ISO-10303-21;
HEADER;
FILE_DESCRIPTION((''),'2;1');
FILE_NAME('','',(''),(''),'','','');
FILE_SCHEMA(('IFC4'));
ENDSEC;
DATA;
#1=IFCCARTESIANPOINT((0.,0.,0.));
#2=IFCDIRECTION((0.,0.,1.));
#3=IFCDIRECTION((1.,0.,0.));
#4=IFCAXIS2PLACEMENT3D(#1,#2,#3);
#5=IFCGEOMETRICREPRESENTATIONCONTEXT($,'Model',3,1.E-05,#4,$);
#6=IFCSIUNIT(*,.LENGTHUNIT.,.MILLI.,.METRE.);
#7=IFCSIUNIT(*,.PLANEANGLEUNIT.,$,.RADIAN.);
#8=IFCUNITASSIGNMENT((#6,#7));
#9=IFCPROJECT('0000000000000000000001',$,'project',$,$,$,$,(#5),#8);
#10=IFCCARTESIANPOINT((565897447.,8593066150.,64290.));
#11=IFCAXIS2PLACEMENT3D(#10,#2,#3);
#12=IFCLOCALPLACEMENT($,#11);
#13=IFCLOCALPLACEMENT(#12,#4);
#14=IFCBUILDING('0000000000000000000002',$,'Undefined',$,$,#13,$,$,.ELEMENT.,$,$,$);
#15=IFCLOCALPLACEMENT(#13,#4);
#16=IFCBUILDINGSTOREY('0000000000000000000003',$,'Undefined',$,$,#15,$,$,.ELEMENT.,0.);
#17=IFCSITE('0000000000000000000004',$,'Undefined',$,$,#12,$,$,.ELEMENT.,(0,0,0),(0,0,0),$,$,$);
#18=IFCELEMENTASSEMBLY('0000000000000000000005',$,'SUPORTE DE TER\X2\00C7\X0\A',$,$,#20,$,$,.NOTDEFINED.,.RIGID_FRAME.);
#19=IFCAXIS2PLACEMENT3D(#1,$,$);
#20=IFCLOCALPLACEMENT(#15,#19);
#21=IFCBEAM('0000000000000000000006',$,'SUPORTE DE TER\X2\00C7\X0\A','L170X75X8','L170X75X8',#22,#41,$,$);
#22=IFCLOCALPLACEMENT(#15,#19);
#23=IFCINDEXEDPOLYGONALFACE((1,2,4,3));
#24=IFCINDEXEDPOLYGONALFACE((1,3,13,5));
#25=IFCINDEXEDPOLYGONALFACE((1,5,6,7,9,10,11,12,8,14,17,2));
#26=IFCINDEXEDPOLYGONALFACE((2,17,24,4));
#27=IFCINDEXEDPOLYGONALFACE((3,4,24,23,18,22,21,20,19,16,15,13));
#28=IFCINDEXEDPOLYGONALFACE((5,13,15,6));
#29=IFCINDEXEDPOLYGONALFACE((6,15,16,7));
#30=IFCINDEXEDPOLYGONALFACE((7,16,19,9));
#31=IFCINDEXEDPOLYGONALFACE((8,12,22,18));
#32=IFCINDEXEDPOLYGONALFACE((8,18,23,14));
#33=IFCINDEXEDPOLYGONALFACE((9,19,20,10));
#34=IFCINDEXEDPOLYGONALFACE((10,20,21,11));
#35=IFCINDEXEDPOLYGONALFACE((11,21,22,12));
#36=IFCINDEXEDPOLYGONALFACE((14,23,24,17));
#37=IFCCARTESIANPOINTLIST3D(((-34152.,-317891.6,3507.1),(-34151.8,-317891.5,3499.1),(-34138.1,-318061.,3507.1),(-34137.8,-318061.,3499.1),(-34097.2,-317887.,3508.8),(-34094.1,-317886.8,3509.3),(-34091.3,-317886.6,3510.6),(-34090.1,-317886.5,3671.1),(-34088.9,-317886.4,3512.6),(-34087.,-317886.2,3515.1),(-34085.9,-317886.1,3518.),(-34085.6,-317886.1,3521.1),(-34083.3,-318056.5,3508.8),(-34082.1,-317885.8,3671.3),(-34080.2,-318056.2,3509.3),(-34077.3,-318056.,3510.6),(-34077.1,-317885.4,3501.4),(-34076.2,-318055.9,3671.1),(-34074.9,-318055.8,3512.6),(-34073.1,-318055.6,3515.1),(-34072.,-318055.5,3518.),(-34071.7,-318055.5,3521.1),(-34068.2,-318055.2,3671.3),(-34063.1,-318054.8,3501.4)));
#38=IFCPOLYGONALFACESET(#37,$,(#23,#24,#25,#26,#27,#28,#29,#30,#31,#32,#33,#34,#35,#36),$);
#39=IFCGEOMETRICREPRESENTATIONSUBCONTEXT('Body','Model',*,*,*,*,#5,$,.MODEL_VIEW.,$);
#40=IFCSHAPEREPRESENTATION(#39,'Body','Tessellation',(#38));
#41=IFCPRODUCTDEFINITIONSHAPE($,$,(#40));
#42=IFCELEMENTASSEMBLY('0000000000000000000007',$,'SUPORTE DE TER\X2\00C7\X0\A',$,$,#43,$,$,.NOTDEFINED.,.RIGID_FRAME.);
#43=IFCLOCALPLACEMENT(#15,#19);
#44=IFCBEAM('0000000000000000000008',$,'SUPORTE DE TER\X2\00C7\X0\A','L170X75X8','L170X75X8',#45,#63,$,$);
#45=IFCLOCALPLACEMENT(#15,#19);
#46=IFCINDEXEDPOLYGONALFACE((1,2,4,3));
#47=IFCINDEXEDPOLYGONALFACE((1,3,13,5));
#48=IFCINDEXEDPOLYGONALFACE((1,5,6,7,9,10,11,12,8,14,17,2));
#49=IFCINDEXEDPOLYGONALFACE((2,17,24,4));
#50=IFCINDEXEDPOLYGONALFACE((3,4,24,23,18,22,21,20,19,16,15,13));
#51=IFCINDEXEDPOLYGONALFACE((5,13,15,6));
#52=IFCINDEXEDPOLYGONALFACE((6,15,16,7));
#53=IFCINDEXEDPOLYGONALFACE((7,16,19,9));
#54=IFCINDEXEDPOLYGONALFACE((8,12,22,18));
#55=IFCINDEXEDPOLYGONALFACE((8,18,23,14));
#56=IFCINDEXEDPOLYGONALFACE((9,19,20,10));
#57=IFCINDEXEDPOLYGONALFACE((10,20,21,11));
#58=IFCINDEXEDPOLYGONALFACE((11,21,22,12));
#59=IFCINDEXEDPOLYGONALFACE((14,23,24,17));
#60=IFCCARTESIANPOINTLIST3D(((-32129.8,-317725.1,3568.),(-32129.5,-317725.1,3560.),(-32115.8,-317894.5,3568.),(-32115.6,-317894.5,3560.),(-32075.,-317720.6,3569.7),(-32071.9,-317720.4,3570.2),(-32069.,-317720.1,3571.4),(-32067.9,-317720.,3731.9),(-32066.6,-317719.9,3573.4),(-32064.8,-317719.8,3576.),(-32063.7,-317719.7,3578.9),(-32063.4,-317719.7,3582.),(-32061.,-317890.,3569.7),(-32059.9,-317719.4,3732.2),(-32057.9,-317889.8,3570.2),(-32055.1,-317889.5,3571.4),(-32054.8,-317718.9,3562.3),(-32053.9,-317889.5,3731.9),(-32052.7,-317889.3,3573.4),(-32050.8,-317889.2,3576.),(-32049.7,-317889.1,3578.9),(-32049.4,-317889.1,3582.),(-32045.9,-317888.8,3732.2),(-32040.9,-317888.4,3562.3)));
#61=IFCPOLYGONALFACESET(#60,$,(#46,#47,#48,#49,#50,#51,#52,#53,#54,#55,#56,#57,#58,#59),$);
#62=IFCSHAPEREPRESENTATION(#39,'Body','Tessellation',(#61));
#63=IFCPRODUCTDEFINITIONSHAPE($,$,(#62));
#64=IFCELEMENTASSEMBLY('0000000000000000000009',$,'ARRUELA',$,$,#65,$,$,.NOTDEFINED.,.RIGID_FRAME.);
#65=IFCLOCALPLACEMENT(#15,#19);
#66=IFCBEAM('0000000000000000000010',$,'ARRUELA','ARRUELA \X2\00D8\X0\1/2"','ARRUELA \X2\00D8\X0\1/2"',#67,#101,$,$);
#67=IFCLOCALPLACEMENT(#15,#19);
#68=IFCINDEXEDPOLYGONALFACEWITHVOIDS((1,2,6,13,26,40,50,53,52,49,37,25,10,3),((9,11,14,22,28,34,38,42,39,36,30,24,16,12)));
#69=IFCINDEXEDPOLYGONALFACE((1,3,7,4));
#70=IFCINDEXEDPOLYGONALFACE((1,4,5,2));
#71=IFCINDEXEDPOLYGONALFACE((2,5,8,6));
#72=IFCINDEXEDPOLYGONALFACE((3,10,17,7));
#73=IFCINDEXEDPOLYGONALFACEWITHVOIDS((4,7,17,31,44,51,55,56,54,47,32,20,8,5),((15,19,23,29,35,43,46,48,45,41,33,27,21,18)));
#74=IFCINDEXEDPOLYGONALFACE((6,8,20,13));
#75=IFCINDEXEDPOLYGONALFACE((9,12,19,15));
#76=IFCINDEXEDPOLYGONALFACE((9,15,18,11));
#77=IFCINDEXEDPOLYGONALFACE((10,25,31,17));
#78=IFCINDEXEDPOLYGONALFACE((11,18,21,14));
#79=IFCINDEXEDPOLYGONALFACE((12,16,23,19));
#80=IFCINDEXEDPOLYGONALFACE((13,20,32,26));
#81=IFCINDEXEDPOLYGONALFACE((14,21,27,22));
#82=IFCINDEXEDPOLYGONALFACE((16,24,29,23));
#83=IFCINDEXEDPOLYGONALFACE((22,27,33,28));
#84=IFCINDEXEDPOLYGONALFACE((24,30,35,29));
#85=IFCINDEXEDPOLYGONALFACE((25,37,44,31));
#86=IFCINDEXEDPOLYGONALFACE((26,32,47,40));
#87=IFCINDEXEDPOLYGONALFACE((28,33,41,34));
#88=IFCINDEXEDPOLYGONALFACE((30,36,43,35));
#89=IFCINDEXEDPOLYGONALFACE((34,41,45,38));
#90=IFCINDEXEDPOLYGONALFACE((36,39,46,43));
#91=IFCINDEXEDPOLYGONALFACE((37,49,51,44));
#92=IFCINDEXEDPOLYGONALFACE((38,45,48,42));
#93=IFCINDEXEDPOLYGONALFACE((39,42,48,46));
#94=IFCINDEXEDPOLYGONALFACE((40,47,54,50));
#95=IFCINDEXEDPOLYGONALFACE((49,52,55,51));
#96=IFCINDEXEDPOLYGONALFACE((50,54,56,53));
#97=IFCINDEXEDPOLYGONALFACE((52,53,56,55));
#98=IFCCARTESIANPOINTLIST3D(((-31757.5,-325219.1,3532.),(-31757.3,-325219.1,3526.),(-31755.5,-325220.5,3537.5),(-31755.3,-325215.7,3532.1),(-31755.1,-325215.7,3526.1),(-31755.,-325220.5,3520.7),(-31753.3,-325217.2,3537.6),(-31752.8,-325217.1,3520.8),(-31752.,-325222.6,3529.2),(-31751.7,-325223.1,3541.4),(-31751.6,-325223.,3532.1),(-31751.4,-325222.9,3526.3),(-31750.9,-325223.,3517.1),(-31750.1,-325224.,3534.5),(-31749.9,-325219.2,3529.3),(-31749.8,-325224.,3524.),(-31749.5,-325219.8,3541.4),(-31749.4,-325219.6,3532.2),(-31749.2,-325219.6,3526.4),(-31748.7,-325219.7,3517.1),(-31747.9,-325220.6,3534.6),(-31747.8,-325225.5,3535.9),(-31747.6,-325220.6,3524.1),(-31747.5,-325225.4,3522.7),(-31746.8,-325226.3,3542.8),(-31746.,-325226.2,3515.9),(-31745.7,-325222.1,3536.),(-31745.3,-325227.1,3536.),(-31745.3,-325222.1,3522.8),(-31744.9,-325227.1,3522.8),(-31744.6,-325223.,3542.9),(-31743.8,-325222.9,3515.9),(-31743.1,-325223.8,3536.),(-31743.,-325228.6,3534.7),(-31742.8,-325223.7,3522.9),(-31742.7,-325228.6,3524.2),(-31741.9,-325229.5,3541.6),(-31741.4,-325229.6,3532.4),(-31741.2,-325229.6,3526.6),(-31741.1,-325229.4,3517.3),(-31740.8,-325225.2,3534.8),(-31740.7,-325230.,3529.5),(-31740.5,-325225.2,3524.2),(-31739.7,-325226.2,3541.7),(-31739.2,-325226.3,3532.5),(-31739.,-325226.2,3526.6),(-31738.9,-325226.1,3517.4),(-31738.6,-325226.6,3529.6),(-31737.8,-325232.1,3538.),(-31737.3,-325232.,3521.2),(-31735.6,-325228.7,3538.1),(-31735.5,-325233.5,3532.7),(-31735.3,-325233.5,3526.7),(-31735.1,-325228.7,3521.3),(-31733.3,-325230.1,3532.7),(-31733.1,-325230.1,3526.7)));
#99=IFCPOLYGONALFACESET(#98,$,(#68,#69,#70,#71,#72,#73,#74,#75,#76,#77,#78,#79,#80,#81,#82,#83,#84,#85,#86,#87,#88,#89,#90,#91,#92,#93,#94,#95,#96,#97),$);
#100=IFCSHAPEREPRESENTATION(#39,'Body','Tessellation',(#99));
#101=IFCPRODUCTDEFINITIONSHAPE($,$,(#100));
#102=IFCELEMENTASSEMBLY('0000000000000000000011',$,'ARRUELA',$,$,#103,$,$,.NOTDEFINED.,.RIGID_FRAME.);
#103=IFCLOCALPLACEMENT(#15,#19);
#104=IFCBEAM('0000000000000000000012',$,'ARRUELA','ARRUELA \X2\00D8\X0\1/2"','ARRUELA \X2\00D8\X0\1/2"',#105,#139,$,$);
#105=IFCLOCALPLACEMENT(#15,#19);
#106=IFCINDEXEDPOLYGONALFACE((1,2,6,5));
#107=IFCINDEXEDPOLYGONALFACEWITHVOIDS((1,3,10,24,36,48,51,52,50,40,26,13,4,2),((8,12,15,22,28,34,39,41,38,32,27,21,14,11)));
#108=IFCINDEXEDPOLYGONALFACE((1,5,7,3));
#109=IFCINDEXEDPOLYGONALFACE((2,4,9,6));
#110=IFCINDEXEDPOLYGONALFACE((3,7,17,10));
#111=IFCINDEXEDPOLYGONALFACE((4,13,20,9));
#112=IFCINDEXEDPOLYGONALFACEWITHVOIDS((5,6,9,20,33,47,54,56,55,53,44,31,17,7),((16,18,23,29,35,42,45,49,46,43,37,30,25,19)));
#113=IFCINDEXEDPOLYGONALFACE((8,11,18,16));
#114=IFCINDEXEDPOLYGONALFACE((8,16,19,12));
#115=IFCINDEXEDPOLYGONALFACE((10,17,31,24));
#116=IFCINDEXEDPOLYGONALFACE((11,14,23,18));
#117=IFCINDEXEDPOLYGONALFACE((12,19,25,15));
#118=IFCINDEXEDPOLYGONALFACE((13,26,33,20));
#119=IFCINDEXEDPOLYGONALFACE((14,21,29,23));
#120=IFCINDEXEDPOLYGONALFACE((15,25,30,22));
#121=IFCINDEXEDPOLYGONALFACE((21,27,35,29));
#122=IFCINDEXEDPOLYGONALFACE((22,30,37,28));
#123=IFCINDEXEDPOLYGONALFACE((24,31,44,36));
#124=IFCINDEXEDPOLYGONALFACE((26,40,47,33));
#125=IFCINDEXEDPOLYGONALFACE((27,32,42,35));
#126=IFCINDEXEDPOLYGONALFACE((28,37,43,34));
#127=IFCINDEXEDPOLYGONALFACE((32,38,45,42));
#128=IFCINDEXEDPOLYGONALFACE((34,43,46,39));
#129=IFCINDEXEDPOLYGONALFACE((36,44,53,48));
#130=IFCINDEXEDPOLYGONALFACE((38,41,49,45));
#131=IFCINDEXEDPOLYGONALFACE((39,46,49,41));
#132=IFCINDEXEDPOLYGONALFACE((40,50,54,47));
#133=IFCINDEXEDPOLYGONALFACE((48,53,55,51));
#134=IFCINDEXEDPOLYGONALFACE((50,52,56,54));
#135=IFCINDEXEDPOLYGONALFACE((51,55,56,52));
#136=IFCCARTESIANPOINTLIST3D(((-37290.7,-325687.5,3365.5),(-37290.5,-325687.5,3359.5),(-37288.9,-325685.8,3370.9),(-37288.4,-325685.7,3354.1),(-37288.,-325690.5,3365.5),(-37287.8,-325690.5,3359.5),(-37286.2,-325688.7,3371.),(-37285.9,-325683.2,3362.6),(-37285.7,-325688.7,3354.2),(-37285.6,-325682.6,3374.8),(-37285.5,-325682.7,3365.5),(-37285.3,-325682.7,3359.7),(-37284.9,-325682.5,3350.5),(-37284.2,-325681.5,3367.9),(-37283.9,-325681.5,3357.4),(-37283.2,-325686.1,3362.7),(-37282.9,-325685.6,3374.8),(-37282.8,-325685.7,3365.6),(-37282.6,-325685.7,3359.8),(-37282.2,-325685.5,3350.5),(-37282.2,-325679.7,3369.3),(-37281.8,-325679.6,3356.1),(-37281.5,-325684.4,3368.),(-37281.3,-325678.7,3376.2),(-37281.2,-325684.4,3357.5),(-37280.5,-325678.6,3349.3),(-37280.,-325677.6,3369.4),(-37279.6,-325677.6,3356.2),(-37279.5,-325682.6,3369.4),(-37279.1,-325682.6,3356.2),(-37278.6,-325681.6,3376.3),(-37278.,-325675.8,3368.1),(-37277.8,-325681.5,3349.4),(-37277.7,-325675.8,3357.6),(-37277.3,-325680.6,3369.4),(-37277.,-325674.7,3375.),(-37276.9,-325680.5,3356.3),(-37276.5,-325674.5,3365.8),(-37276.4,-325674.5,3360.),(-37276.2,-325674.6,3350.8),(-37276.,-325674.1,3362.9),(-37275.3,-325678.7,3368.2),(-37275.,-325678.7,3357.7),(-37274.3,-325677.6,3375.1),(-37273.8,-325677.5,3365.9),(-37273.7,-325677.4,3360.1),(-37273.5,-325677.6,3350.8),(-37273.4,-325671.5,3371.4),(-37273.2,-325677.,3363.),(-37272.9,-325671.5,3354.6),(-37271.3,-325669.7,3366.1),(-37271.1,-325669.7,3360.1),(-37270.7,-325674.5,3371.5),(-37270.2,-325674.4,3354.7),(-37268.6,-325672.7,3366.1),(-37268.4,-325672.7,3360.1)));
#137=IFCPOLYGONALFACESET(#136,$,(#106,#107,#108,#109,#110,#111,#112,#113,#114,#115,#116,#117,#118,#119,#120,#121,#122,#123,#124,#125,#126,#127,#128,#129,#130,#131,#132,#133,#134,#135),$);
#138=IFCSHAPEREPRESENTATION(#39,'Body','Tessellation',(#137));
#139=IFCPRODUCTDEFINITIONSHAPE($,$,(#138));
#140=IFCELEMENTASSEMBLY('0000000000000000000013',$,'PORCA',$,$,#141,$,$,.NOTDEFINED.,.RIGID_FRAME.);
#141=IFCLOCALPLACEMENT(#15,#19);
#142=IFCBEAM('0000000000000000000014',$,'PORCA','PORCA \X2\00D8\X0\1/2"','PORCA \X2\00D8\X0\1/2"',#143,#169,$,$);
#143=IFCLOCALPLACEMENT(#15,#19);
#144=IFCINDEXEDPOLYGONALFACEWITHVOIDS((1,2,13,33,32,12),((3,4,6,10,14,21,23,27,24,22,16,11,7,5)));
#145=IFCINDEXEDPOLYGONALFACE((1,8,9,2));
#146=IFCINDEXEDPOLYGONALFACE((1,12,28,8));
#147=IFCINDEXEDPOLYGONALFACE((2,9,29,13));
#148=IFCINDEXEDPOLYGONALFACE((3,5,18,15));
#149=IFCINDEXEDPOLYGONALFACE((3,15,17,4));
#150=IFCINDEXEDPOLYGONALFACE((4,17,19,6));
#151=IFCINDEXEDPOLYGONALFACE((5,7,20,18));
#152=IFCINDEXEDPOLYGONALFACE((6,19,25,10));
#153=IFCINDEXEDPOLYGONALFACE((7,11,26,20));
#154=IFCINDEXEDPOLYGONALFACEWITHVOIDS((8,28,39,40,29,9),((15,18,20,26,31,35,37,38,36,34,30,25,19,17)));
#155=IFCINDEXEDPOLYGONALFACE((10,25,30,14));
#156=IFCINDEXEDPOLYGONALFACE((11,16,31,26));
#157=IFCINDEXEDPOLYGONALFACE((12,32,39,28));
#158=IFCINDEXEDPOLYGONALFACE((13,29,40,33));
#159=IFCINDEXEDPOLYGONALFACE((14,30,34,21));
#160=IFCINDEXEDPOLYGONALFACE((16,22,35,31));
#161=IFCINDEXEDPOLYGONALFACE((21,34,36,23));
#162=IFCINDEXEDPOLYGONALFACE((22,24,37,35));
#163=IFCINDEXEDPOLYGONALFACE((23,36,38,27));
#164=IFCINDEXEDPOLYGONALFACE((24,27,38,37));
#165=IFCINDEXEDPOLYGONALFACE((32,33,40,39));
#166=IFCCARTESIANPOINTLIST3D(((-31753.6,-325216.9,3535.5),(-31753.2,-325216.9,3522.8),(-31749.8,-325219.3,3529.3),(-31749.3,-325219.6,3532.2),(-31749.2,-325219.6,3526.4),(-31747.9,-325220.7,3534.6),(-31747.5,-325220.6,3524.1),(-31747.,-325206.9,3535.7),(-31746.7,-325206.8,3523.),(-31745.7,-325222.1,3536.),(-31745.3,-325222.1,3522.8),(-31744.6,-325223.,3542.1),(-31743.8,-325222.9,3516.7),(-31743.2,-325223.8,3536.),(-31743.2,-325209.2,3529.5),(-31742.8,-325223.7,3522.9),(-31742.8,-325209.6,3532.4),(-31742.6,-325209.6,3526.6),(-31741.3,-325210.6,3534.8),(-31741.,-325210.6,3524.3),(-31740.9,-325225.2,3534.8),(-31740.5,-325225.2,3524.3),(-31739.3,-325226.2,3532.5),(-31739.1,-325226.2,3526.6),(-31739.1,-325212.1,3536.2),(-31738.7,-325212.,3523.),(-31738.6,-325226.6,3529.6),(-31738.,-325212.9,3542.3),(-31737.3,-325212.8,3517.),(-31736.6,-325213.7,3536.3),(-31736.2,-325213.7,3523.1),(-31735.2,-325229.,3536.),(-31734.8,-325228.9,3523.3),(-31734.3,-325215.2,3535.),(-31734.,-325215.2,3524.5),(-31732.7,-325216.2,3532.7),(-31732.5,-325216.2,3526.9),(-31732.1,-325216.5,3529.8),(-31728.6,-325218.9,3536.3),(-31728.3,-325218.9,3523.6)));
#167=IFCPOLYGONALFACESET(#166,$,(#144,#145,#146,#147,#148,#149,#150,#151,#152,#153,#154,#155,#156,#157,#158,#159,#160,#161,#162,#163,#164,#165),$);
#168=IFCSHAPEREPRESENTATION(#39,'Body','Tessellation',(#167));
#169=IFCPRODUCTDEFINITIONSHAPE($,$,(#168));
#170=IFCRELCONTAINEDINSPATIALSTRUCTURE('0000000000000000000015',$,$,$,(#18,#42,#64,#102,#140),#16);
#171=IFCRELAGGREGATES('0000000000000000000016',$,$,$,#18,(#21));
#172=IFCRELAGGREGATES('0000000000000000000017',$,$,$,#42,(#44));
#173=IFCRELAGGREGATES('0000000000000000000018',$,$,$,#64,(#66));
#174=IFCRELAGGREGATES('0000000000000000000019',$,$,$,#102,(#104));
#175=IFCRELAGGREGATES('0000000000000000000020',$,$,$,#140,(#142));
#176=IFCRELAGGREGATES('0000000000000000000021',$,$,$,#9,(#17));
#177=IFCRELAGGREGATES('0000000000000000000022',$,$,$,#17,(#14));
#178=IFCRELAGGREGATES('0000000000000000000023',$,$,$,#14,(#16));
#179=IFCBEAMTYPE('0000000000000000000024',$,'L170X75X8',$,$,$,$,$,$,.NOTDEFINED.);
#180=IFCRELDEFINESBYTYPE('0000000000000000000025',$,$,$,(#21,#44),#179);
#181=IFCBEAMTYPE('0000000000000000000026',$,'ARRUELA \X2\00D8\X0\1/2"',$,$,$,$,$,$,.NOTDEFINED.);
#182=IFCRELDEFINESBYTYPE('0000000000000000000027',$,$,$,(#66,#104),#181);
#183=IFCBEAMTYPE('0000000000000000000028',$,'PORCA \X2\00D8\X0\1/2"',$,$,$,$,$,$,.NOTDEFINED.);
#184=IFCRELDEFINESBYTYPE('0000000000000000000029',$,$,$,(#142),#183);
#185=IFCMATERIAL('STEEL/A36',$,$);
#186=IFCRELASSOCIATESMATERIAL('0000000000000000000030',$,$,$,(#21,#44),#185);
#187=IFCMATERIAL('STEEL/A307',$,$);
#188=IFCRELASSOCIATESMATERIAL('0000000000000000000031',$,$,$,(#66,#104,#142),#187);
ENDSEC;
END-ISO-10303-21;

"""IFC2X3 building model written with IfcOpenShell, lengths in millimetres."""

from ifc_helpers import new_model, si_unit, frame, origin_with_axes, origin_2d_with_axis, place, context, subcontext, project, spatial, polyline, l_section, outline, extrude, material, type_object, element, aggregate, save


model = new_model("IFC2X3")

# Units and contexts
model_context = context("Model", 3, precision=1e-05, world=origin_with_axes())
body_context = subcontext(model_context, "Body", "Model", "MODEL_VIEW")
ifc_project = project(units=[si_unit("LENGTHUNIT", "METRE", prefix="MILLI"), si_unit("PLANEANGLEUNIT", "RADIAN")], contexts=[model_context])

# Site, building, storey
site_placement = place(None, frame((565897447.0, 8593066150.0, 64290.0), z_axis=(0.0, 0.0, 1.0), x_axis=(1.0, 0.0, 0.0)))
site = spatial("IfcSite", under=ifc_project, at=site_placement, Name="Undefined", CompositionType="ELEMENT", RefLatitude=(0, 0, 0), RefLongitude=(0, 0, 0))
building_placement = place(site_placement, origin_with_axes())
building = spatial("IfcBuilding", under=site, at=building_placement, Name="Undefined", CompositionType="ELEMENT")
storey_placement = place(building_placement, origin_with_axes())
storey = spatial("IfcBuildingStorey", under=building, at=storey_placement, Name="Undefined", CompositionType="ELEMENT", Elevation=0.0)

# Element assemblies, beams
ifc_material_1 = material(Name="STEEL/A36")
beam_type_1 = type_object("IfcBeamType", Name="L170X75X8", PredefinedType="NOTDEFINED")
assembly_1_placement = place(storey_placement, origin_with_axes())
assembly_1 = element("IfcElementAssembly", 1, at=assembly_1_placement, inside=storey, Name="SUPORTE DE TERÇA", AssemblyPlace="NOTDEFINED", PredefinedType="RIGID_FRAME")
beam_1_placement = place(assembly_1_placement, frame((-34117.0, -317888.7, 3585.2), z_axis=(-0.029885, -0.00246, 0.99955), x_axis=(0.082025, -0.99663, 0.0)))
beam_1 = element("IfcBeam", 2, at=beam_1_placement, type_object=beam_type_1, material=ifc_material_1, Name="SUPORTE DE TERÇA", Description="L170X75X8", ObjectType="L170X75X8", context=body_context, shape_type="SweptSolid", body=[
    extrude(l_section(Depth=170.0, Width=75.0, Thickness=8.0, FilletRadius=12.0, at=origin_2d_with_axis()), frame((170.0, 0.0, 0.0), z_axis=(-1.0, 0.0, 0.0), x_axis=(0.0, -1.0, 0.0)), (0.0, 0.0, 1.0), 170.0),
])
aggregate(assembly_1, [beam_1])
assembly_2_placement = place(storey_placement, origin_with_axes())
assembly_2 = element("IfcElementAssembly", 3, at=assembly_2_placement, inside=storey, Name="SUPORTE DE TERÇA", AssemblyPlace="NOTDEFINED", PredefinedType="RIGID_FRAME")
beam_2_placement = place(assembly_2_placement, frame((-32094.7, -317722.2, 3646.1), z_axis=(-0.029885, -0.00246, 0.99955), x_axis=(0.082025, -0.99663, 0.0)))
beam_2 = element("IfcBeam", 4, at=beam_2_placement, type_object=beam_type_1, material=ifc_material_1, Name="SUPORTE DE TERÇA", Description="L170X75X8", ObjectType="L170X75X8", context=body_context, shape_type="SweptSolid", body=[
    extrude(l_section(Depth=170.0, Width=75.0, Thickness=8.0, FilletRadius=12.0, at=origin_2d_with_axis()), frame((170.0, 0.0, 0.0), z_axis=(-1.0, 0.0, 0.0), x_axis=(0.0, -1.0, 0.0)), (0.0, 0.0, 1.0), 170.0),
])
aggregate(assembly_2, [beam_2])
assembly_3_placement = place(storey_placement, origin_with_axes())
assembly_3 = element("IfcElementAssembly", 5, at=assembly_3_placement, inside=storey, Name="ARRUELA", AssemblyPlace="NOTDEFINED", PredefinedType="RIGID_FRAME")
ifc_material_2 = material(Name="STEEL/A307")
beam_type_2 = type_object("IfcBeamType", Name="ARRUELA Ø1/2\"", PredefinedType="NOTDEFINED")
beam_3_placement = place(assembly_3_placement, frame((-31744.2, -325222.9, 3529.4), z_axis=(0.836984, -0.546715, 0.02368), x_axis=(-0.546411, -0.837315, -0.018398)))
beam_3 = element("IfcBeam", 6, at=beam_3_placement, type_object=beam_type_2, material=ifc_material_2, Name="ARRUELA", Description="ARRUELA Ø1/2\"", ObjectType="ARRUELA Ø1/2\"", context=body_context, shape_type="SweptSolid", body=[
    extrude(outline(polyline([(-8.4, 10.5), (-3.0, 13.2), (3.0, 13.2), (8.4, 10.5), (12.2, 5.9), (13.5, 0.0), (12.2, -5.9), (8.4, -10.5), (3.0, -13.2), (-3.0, -13.2), (-8.4, -10.5), (-12.2, -5.9), (-13.5, 0.0), (-12.2, 5.9), (-8.4, 10.5)]), holes=[polyline([(5.3, 4.2), (2.9, 6.1), (0.0, 6.7), (-2.9, 6.1), (-5.3, 4.2), (-6.6, 1.5), (-6.6, -1.5), (-5.3, -4.2), (-2.9, -6.1), (0.0, -6.8), (2.9, -6.1), (5.3, -4.2), (6.6, -1.5), (6.6, 1.5), (5.3, 4.2)])]), frame((4.0, 0.0, 0.0), z_axis=(-1.0, 0.0, 0.0), x_axis=(0.0, -1.0, 0.0)), (0.0, 0.0, 1.0), 4.0),
])
aggregate(assembly_3, [beam_3])
assembly_4_placement = place(storey_placement, origin_with_axes())
assembly_4 = element("IfcElementAssembly", 7, at=assembly_4_placement, inside=storey, Name="ARRUELA", AssemblyPlace="NOTDEFINED", PredefinedType="RIGID_FRAME")
beam_4_placement = place(assembly_4_placement, frame((-37280.9, -325678.6, 3362.8), z_axis=(0.736334, 0.676203, 0.02368), x_axis=(0.675958, -0.736711, 0.018398)))
beam_4 = element("IfcBeam", 8, at=beam_4_placement, type_object=beam_type_2, material=ifc_material_2, Name="ARRUELA", Description="ARRUELA Ø1/2\"", ObjectType="ARRUELA Ø1/2\"", context=body_context, shape_type="SweptSolid", body=[
    extrude(outline(polyline([(-8.4, 10.5), (-3.0, 13.2), (3.0, 13.2), (8.4, 10.5), (12.2, 5.9), (13.5, 0.0), (12.2, -5.9), (8.4, -10.5), (3.0, -13.2), (-3.0, -13.2), (-8.4, -10.5), (-12.2, -5.9), (-13.5, 0.0), (-12.2, 5.9), (-8.4, 10.5)]), holes=[polyline([(5.3, 4.2), (2.9, 6.1), (0.0, 6.7), (-2.9, 6.1), (-5.3, 4.2), (-6.6, 1.5), (-6.6, -1.5), (-5.3, -4.2), (-2.9, -6.1), (0.0, -6.8), (2.9, -6.1), (5.3, -4.2), (6.6, -1.5), (6.6, 1.5), (5.3, 4.2)])]), frame((4.0, 0.0, 0.0), z_axis=(-1.0, 0.0, 0.0), x_axis=(0.0, -1.0, 0.0)), (0.0, 0.0, 1.0), 4.0),
])
aggregate(assembly_4, [beam_4])
assembly_5_placement = place(storey_placement, origin_with_axes())
assembly_5 = element("IfcElementAssembly", 9, at=assembly_5_placement, inside=storey, Name="PORCA", AssemblyPlace="NOTDEFINED", PredefinedType="RIGID_FRAME")
beam_type_3 = type_object("IfcBeamType", Name="PORCA Ø1/2\"", PredefinedType="NOTDEFINED")
beam_5_placement = place(assembly_5_placement, frame((-31737.6, -325212.9, 3529.6), z_axis=(0.836984, -0.546715, 0.02368), x_axis=(-0.546411, -0.837315, -0.018398)))
beam_5 = element("IfcBeam", 10, at=beam_5_placement, type_object=beam_type_3, material=ifc_material_2, Name="PORCA", Description="PORCA Ø1/2\"", ObjectType="PORCA Ø1/2\"", context=body_context, shape_type="SweptSolid", body=[
    extrude(outline(polyline([(-12.7, 0.0), (-6.3, 11.0), (6.3, 11.0), (12.7, 0.0), (6.3, -11.0), (-6.3, -11.0), (-12.7, 0.0)]), holes=[polyline([(5.3, 4.2), (2.9, 6.0), (0.0, 6.7), (-2.9, 6.0), (-5.3, 4.2), (-6.6, 1.5), (-6.6, -1.5), (-5.3, -4.2), (-2.9, -6.0), (0.0, -6.7), (2.9, -6.0), (5.3, -4.2), (6.6, -1.5), (6.6, 1.5), (5.3, 4.2)])]), frame((12.0, 0.0, 0.0), z_axis=(-1.0, 0.0, 0.0), x_axis=(0.0, -1.0, 0.0)), (0.0, 0.0, 1.0), 12.0),
])
aggregate(assembly_5, [beam_5])

save(model, "model.ifc")
